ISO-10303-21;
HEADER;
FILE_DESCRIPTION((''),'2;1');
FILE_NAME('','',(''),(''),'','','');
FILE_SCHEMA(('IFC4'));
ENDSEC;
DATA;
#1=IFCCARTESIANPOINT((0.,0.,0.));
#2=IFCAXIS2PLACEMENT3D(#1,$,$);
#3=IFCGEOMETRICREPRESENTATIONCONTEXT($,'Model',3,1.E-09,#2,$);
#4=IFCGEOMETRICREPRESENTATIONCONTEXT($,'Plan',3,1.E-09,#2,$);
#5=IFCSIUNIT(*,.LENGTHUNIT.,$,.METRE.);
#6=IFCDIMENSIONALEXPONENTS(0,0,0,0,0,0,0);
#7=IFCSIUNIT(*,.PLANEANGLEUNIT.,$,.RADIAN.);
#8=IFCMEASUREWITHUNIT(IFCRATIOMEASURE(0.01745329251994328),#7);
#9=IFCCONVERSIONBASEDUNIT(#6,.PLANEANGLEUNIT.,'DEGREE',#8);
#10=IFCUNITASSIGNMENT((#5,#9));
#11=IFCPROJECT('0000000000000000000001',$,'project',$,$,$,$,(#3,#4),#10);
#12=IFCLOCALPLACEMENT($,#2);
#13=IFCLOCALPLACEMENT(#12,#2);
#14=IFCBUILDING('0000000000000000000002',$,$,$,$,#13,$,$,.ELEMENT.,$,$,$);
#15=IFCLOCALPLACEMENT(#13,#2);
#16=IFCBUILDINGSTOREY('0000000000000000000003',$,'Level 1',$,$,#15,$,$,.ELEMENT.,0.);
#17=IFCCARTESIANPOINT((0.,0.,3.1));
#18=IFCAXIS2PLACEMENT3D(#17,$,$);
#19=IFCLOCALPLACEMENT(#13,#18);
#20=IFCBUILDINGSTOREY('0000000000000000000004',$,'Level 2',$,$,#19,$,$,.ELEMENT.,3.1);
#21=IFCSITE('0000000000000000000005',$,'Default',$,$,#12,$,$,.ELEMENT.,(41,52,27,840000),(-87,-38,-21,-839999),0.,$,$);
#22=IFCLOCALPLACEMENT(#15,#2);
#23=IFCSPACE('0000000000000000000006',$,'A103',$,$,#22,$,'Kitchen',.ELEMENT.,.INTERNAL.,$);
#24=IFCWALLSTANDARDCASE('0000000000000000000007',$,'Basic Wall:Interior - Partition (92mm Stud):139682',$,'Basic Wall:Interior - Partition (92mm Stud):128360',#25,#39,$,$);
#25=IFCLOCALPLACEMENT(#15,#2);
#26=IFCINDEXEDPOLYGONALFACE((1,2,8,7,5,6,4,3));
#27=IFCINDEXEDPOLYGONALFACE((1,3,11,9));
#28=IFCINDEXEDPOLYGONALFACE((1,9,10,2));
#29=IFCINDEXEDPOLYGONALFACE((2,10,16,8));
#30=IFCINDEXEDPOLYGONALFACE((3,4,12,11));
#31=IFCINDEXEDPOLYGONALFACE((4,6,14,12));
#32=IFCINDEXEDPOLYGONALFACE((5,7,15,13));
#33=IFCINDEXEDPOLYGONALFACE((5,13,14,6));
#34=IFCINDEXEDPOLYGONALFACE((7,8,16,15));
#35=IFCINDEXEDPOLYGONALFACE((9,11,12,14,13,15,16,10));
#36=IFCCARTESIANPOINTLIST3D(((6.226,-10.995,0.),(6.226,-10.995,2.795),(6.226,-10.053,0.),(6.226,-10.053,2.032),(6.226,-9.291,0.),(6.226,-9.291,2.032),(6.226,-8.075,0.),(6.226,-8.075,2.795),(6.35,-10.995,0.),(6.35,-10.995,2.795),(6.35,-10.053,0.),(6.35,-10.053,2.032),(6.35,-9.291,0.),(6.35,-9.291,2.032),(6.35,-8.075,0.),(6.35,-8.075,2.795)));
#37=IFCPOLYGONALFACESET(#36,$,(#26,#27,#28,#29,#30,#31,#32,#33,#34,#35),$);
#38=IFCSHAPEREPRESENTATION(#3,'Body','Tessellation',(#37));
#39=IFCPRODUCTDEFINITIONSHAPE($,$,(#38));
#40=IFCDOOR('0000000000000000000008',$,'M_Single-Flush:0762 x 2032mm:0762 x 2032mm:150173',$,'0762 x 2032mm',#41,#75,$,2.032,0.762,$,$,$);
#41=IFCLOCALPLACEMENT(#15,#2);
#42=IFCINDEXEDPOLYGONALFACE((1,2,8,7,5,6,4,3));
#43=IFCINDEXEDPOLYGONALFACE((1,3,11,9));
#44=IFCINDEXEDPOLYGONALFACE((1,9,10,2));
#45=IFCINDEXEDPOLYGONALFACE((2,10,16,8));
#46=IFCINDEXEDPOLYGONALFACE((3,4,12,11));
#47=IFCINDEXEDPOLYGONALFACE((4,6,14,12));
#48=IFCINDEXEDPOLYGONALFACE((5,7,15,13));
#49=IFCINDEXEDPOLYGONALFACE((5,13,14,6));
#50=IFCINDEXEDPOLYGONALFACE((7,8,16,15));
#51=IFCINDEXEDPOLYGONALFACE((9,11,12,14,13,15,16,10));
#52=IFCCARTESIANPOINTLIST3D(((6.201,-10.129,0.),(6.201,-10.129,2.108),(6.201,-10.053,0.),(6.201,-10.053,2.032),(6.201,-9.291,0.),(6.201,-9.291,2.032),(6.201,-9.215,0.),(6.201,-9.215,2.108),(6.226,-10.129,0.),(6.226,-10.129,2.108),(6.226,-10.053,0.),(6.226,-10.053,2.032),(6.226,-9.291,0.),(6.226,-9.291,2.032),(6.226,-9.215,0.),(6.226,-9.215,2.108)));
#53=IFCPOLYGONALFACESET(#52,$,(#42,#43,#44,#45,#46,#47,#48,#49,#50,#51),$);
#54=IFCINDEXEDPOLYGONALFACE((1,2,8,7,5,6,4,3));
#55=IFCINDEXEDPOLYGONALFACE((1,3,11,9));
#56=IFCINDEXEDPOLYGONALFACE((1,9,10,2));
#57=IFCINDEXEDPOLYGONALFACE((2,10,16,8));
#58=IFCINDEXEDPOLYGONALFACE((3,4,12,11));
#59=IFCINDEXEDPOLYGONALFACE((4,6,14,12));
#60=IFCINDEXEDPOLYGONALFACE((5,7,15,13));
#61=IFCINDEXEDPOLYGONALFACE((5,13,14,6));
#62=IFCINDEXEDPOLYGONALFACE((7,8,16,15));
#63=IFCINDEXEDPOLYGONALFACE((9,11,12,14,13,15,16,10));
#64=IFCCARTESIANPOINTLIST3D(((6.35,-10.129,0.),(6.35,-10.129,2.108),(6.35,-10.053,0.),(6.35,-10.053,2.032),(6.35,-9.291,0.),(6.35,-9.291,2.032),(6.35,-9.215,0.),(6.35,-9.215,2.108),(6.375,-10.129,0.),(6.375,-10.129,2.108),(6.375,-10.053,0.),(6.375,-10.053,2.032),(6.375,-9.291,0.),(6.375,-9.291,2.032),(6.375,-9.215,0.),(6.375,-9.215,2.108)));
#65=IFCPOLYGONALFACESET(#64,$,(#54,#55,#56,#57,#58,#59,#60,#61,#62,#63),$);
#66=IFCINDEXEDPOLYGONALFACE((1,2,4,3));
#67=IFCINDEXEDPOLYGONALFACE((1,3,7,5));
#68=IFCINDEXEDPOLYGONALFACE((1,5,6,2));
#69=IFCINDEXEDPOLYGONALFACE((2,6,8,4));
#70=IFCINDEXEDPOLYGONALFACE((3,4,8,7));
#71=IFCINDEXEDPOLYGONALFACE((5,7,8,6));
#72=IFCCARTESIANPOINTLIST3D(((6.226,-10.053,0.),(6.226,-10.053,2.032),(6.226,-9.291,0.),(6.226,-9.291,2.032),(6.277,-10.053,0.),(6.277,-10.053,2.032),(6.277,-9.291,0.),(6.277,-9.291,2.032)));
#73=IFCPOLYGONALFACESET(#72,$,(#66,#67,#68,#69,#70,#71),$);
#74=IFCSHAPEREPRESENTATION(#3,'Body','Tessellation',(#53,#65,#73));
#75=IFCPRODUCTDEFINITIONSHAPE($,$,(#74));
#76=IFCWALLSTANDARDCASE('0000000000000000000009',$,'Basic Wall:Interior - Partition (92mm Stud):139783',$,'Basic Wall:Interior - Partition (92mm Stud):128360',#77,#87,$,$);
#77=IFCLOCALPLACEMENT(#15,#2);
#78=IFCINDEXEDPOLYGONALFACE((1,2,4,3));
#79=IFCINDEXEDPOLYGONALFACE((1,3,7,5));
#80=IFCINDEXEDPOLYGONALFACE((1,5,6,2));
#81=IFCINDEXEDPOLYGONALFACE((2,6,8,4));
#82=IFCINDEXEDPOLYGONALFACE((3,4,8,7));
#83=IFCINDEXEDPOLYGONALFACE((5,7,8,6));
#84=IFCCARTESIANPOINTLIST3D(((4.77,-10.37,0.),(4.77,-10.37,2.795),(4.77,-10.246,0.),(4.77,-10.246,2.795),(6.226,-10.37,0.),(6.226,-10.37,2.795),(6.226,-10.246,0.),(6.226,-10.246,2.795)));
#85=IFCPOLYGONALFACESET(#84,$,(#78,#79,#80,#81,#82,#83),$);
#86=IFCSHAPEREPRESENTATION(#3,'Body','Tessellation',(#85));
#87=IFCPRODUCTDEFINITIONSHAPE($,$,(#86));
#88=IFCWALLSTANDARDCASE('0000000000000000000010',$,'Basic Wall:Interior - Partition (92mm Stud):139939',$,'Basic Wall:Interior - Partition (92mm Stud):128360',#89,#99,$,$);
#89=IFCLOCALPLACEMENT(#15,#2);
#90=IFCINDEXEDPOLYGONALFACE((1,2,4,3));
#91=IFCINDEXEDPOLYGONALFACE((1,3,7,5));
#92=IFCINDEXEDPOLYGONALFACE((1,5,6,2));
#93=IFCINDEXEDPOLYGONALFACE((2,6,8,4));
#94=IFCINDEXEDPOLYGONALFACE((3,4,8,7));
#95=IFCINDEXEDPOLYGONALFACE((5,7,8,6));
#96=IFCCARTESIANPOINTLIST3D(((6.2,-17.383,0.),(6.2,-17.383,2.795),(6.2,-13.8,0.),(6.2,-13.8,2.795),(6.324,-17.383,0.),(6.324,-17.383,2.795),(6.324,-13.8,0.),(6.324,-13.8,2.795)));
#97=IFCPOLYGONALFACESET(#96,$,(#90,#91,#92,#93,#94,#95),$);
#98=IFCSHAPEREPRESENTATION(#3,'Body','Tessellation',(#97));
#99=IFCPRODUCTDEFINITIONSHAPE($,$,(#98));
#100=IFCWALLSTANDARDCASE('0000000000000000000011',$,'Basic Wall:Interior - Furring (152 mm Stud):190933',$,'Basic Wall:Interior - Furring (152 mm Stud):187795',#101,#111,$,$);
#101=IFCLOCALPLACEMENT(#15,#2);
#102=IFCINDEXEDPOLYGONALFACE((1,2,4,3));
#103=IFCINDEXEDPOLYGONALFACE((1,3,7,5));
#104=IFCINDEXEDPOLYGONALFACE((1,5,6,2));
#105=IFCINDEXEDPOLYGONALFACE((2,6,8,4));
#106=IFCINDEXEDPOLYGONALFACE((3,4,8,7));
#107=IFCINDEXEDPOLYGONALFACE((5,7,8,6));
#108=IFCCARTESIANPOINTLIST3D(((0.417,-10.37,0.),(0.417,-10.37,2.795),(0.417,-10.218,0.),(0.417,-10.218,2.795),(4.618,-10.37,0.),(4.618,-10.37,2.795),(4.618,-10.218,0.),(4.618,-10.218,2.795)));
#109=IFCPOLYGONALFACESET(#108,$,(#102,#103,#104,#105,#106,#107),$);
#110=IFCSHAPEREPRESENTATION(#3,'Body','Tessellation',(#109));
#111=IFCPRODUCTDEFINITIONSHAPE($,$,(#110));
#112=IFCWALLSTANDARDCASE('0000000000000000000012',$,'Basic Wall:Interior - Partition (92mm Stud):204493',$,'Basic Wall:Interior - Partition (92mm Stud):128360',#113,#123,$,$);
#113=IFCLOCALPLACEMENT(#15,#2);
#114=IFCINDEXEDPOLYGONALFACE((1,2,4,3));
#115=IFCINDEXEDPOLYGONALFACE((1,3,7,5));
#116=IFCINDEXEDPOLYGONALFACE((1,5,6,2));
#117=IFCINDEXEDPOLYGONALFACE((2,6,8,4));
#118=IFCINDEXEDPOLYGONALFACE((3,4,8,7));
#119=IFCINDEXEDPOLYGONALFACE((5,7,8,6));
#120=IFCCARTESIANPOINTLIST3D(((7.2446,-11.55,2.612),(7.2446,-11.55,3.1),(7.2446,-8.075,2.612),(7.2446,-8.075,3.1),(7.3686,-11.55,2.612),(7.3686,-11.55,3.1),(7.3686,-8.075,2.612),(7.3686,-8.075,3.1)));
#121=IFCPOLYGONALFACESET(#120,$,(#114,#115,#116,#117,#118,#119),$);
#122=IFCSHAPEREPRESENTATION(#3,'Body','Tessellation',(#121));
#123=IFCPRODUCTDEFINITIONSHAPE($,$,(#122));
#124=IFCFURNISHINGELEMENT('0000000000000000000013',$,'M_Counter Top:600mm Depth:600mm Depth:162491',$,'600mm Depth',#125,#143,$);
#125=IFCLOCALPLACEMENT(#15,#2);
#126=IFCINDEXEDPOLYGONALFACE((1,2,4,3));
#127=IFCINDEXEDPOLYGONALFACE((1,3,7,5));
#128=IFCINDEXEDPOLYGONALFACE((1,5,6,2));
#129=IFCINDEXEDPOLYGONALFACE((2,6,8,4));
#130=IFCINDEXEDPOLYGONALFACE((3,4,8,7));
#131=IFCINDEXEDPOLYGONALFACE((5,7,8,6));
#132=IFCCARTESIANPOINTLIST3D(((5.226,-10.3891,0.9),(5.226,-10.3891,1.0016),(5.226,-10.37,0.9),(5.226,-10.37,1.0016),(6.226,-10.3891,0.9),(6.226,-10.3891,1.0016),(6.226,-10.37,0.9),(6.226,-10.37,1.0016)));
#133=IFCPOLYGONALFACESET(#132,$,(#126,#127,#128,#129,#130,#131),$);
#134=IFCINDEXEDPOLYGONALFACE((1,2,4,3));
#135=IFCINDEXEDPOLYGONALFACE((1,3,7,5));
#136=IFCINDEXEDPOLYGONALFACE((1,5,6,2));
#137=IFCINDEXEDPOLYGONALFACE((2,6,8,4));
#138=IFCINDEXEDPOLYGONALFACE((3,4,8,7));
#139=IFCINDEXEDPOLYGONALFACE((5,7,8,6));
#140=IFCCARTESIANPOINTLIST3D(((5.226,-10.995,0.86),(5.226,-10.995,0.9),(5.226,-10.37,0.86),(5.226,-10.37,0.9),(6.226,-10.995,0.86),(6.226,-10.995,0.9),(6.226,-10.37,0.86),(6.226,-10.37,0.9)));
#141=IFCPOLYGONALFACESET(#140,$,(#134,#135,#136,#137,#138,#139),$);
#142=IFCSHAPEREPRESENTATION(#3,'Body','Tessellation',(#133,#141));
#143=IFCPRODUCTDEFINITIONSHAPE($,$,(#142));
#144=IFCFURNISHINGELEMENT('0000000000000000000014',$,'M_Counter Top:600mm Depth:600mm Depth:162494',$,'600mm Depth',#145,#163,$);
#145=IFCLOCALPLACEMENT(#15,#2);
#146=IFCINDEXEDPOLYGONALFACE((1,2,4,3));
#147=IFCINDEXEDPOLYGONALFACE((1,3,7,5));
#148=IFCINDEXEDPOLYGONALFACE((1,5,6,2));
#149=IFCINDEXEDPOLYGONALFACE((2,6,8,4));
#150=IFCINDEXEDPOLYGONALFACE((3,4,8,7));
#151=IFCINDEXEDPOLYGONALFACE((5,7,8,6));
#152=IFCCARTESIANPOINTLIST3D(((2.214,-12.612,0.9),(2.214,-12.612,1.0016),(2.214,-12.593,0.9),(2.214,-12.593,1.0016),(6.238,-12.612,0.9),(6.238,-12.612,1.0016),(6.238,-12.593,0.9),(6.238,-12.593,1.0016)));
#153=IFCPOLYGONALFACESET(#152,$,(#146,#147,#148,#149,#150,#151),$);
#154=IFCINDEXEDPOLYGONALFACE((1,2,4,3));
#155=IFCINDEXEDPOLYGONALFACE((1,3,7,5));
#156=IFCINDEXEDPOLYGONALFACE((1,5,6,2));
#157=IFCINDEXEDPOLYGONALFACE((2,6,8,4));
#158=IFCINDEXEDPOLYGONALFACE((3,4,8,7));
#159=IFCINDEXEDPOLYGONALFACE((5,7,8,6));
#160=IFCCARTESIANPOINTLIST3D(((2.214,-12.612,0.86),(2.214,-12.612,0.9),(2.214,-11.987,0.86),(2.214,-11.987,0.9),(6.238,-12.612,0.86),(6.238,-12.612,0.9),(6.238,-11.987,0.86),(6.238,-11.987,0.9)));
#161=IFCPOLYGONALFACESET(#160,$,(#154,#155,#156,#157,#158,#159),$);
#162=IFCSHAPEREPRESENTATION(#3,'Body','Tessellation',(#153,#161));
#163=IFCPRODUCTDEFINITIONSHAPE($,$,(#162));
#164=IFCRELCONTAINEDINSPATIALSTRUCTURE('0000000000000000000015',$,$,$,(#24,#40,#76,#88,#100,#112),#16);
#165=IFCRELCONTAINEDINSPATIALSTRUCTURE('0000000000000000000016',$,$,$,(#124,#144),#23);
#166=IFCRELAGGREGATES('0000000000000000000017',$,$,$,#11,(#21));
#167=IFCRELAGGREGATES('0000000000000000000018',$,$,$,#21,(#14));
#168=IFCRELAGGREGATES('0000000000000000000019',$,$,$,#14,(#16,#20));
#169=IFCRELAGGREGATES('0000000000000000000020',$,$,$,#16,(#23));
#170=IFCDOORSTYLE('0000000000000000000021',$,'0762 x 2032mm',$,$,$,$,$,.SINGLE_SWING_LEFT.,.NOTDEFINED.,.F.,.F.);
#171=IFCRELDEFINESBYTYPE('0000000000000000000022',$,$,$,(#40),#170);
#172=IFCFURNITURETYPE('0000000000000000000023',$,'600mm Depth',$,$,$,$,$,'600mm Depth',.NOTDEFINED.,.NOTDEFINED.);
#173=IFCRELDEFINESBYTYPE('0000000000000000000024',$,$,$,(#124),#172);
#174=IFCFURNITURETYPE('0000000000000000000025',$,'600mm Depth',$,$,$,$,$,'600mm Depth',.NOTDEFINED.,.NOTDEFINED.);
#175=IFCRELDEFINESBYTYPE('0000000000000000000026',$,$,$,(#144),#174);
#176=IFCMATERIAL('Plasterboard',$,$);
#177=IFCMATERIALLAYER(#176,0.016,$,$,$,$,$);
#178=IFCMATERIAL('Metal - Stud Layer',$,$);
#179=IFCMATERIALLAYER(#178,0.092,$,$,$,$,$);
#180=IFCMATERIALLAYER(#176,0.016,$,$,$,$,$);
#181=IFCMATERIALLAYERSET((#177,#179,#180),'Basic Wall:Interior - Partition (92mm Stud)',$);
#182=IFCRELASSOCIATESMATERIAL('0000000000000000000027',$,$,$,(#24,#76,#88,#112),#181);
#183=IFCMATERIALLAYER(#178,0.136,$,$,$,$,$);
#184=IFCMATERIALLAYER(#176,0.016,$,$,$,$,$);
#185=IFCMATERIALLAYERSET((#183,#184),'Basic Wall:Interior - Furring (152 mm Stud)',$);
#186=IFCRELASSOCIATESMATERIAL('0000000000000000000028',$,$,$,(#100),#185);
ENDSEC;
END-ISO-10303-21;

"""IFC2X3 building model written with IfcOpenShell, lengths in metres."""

from ifc_helpers import new_model, entity, si_unit, converted_unit, frame, frame_2d, origin, origin_2d_with_axis, place, context, project, spatial, polyline, rectangle, outline, extrude, source, transform, mapped, material, layer, layer_set, layer_usage, type_object, type_shapes, element, fill, save


model = new_model("IFC2X3")

# Units and contexts
model_context = context("Model", 3, precision=1e-09, world=origin())
plan_context = context("Plan", 3, precision=1e-09, world=origin())
ifc_project = project(units=[si_unit("LENGTHUNIT", "METRE"), converted_unit("PLANEANGLEUNIT", "DEGREE", entity("IfcRatioMeasure", 0.01745329251994328), si_unit("PLANEANGLEUNIT", "RADIAN"), dimensions=[0, 0, 0, 0, 0, 0, 0])], contexts=[model_context, plan_context])

# Site, building, storey
site_placement = place(None, origin())
site = spatial("IfcSite", under=ifc_project, at=site_placement, Name="Default", CompositionType="ELEMENT", RefLatitude=(41, 52, 27, 840000), RefLongitude=(-87, -38, -21, -839999), RefElevation=0.0)
building_placement = place(site_placement, origin())
building = spatial("IfcBuilding", under=site, at=building_placement, CompositionType="ELEMENT")
storey_1_placement = place(building_placement, origin())
storey_1 = spatial("IfcBuildingStorey", under=building, at=storey_1_placement, Name="Level 1", CompositionType="ELEMENT", Elevation=0.0)

# Shared definitions
ifc_material_1 = material(Name="Metal - Stud Layer")
ifc_material_2 = material(Name="Plasterboard")

# Wall, opening, door
ifc_layer_1 = layer(ifc_material_2, 0.016)
ifc_layer_2 = layer(ifc_material_1, 0.092)
ifc_layer_3 = layer(ifc_material_2, 0.016)
ifc_layer_set_1 = layer_set([ifc_layer_1, ifc_layer_2, ifc_layer_3], Name="Basic Wall:Interior - Partition (92mm Stud)")
ifc_layer_usage_1 = layer_usage(ifc_layer_set_1, "AXIS2", "NEGATIVE", 0.062)
wall_1_placement = place(storey_1_placement, frame((6.288, -10.995, 0.0), z_axis=(0.0, 0.0, 1.0), x_axis=(0.0, 1.0, 0.0)))
wall_1 = element("IfcWallStandardCase", 1, at=wall_1_placement, inside=storey_1, material=ifc_layer_usage_1, Name="Basic Wall:Interior - Partition (92mm Stud):139682", ObjectType="Basic Wall:Interior - Partition (92mm Stud):128360", context=model_context, shape_type="SweptSolid", body=[
    extrude(rectangle(XDim=2.92, YDim=0.124, at=frame_2d((1.46, 0.0), x_axis=(-1.0, 0.0))), origin(), (0.0, 0.0, 1.0), 2.795),
])
opening_1_placement = place(wall_1_placement, frame((0.942, -0.062, 0.0)))
opening_1 = element("IfcOpeningElement", 2, at=opening_1_placement, cuts=wall_1, ObjectType="Opening", context=model_context, shape_type="SweptSolid", body=[
    extrude(rectangle(XDim=0.762, YDim=2.032, at=frame_2d((1.016, 0.381), x_axis=(0.0, -1.0))), frame((0.0, 0.0, 0.0), z_axis=(0.0, 1.0, 0.0), x_axis=(0.0, 0.0, 1.0)), (0.0, 0.0, 1.0), 0.124),
])
door_style_1 = type_object("IfcDoorStyle", Name="0762 x 2032mm", ConstructionType="NOTDEFINED", OperationType="SINGLE_SWING_LEFT", ParameterTakesPrecedence=False, Sizeable=False)
shared_shape_1 = source(origin(), model_context, "Body", "SweptSolid", [
    extrude(outline(polyline([(-0.457, -1.073), (0.457, -1.073), (0.457, 1.035), (0.381, 1.035), (0.381, -0.997), (-0.381, -0.997), (-0.381, 1.035), (-0.457, 1.035), (-0.457, -1.073)])), frame((0.381, 0.149, 1.035), z_axis=(0.0, -1.0, 0.0), x_axis=(-1.0, 0.0, 0.0)), (0.0, 0.0, 1.0), 0.025),
    extrude(outline(polyline([(-1.073, -0.457), (1.035, -0.457), (1.035, -0.381), (-0.997, -0.381), (-0.997, 0.381), (1.035, 0.381), (1.035, 0.457), (-1.073, 0.457), (-1.073, -0.457)])), frame((0.381, 0.0, 1.035), z_axis=(0.0, -1.0, 0.0), x_axis=(0.0, 0.0, -1.0)), (0.0, 0.0, 1.0), 0.025),
    extrude(rectangle(XDim=0.762, YDim=0.051, at=origin_2d_with_axis()), frame((0.381, 0.0985, 0.0)), (0.0, 0.0, 1.0), 2.032),
])
type_shapes(door_style_1, [shared_shape_1])
door_1_placement = place(opening_1_placement, origin())
door_1 = element("IfcDoor", 3, at=door_1_placement, inside=storey_1, type_object=door_style_1, Name="M_Single-Flush:0762 x 2032mm:0762 x 2032mm:150173", ObjectType="0762 x 2032mm", OverallHeight=2.032, OverallWidth=0.762, context=model_context, shape_type="MappedRepresentation", body=[
    mapped(shared_shape_1, transform((0.0, 0.0, 0.0), scale=1.0)),
])
fill(opening_1, door_1)

# Walls
ifc_layer_usage_2 = layer_usage(ifc_layer_set_1, "AXIS2", "NEGATIVE", 0.062)
wall_2_placement = place(storey_1_placement, frame((4.77, -10.308, 0.0)))
element("IfcWallStandardCase", 4, at=wall_2_placement, inside=storey_1, material=ifc_layer_usage_2, Name="Basic Wall:Interior - Partition (92mm Stud):139783", ObjectType="Basic Wall:Interior - Partition (92mm Stud):128360", context=model_context, shape_type="SweptSolid", body=[
    extrude(rectangle(XDim=1.456, YDim=0.124, at=frame_2d((0.728, 0.0), x_axis=(-1.0, 0.0))), origin(), (0.0, 0.0, 1.0), 2.795),
])
ifc_layer_usage_3 = layer_usage(ifc_layer_set_1, "AXIS2", "NEGATIVE", 0.062)
wall_3_placement = place(storey_1_placement, frame((6.262, -13.8, 0.0), z_axis=(0.0, 0.0, 1.0), x_axis=(0.0, -1.0, 0.0)))
element("IfcWallStandardCase", 5, at=wall_3_placement, inside=storey_1, material=ifc_layer_usage_3, Name="Basic Wall:Interior - Partition (92mm Stud):139939", ObjectType="Basic Wall:Interior - Partition (92mm Stud):128360", context=model_context, shape_type="SweptSolid", body=[
    extrude(rectangle(XDim=3.583, YDim=0.124, at=frame_2d((1.7915, 0.0), x_axis=(-1.0, 0.0))), origin(), (0.0, 0.0, 1.0), 2.795),
])

# Shared definitions
storey_2_placement = place(building_placement, frame((0.0, 0.0, 3.1)))
storey_2 = spatial("IfcBuildingStorey", under=building, at=storey_2_placement, Name="Level 2", CompositionType="ELEMENT", Elevation=3.1)

# Walls
ifc_layer_4 = layer(ifc_material_1, 0.136)
ifc_layer_5 = layer(ifc_material_2, 0.016)
ifc_layer_set_2 = layer_set([ifc_layer_4, ifc_layer_5], Name="Basic Wall:Interior - Furring (152 mm Stud)")
ifc_layer_usage_4 = layer_usage(ifc_layer_set_2, "AXIS2", "NEGATIVE", 0.076)
wall_4_placement = place(storey_1_placement, frame((0.417, -10.294, 0.0)))
element("IfcWallStandardCase", 6, at=wall_4_placement, inside=storey_1, material=ifc_layer_usage_4, Name="Basic Wall:Interior - Furring (152 mm Stud):190933", ObjectType="Basic Wall:Interior - Furring (152 mm Stud):187795", context=model_context, shape_type="SweptSolid", body=[
    extrude(rectangle(XDim=4.201, YDim=0.152, at=frame_2d((2.1005, 0.0), x_axis=(-1.0, 0.0))), origin(), (0.0, 0.0, 1.0), 2.795),
])
ifc_layer_usage_5 = layer_usage(ifc_layer_set_1, "AXIS2", "NEGATIVE", 0.062)
wall_5_placement = place(storey_1_placement, frame((7.3066, -11.55, 2.612), z_axis=(0.0, 0.0, 1.0), x_axis=(0.0, 1.0, 0.0)))
element("IfcWallStandardCase", 7, at=wall_5_placement, inside=storey_1, material=ifc_layer_usage_5, Name="Basic Wall:Interior - Partition (92mm Stud):204493", ObjectType="Basic Wall:Interior - Partition (92mm Stud):128360", context=model_context, shape_type="SweptSolid", body=[
    extrude(rectangle(XDim=3.475, YDim=0.124, at=frame_2d((1.7375, 0.0), x_axis=(-1.0, 0.0))), origin(), (0.0, 0.0, 1.0), 0.488),
])

# Shared definitions
space_1_placement = place(storey_1_placement, origin())
space_1 = spatial("IfcSpace", under=storey_1, at=space_1_placement, Name="A103", LongName="Kitchen", CompositionType="ELEMENT", InteriorOrExteriorSpace="INTERNAL")

# Furnishing elements
furniture_type_1 = type_object("IfcFurnitureType", Name="600mm Depth", ElementType="600mm Depth", AssemblyPlace="NOTDEFINED")
shared_shape_2 = source(origin(), model_context, "Body", "SweptSolid", [
    extrude(rectangle(XDim=0.0191, YDim=1.0, at=origin_2d_with_axis()), frame((-0.7005, -0.0095, 0.9), z_axis=(0.0, 0.0, 1.0), x_axis=(0.0, -1.0, 0.0)), (0.0, 0.0, 1.0), 0.1016),
    extrude(rectangle(XDim=1.0, YDim=0.625, at=origin_2d_with_axis()), frame((-0.7005, -0.3125, 0.86), z_axis=(0.0, 0.0, 1.0), x_axis=(-1.0, 0.0, 0.0)), (0.0, 0.0, 1.0), 0.04),
])
type_shapes(furniture_type_1, [shared_shape_2])
furnishing_1_placement = place(space_1_placement, frame((6.4265, -10.37, 0.0)))
element("IfcFurnishingElement", 8, at=furnishing_1_placement, inside=space_1, type_object=furniture_type_1, Name="M_Counter Top:600mm Depth:600mm Depth:162491", ObjectType="600mm Depth", context=model_context, shape_type="MappedRepresentation", body=[
    mapped(shared_shape_2, transform((0.0, 0.0, 0.0), scale=1.0)),
])
furniture_type_2 = type_object("IfcFurnitureType", Name="600mm Depth", ElementType="600mm Depth", AssemblyPlace="NOTDEFINED")
shared_shape_3 = source(origin(), model_context, "Body", "SweptSolid", [
    extrude(rectangle(XDim=0.0191, YDim=4.024, at=origin_2d_with_axis()), frame((0.8115, -0.0095, 0.9), z_axis=(0.0, 0.0, 1.0), x_axis=(0.0, -1.0, 0.0)), (0.0, 0.0, 1.0), 0.1016),
    extrude(rectangle(XDim=4.024, YDim=0.625, at=origin_2d_with_axis()), frame((0.8115, -0.3125, 0.86), z_axis=(0.0, 0.0, 1.0), x_axis=(-1.0, 0.0, 0.0)), (0.0, 0.0, 1.0), 0.04),
])
type_shapes(furniture_type_2, [shared_shape_3])
furnishing_2_placement = place(space_1_placement, frame((5.0375, -12.612, 0.0), z_axis=(0.0, 0.0, 1.0), x_axis=(-1.0, 0.0, 0.0)))
element("IfcFurnishingElement", 9, at=furnishing_2_placement, inside=space_1, type_object=furniture_type_2, Name="M_Counter Top:600mm Depth:600mm Depth:162494", ObjectType="600mm Depth", context=model_context, shape_type="MappedRepresentation", body=[
    mapped(shared_shape_3, transform((0.0, 0.0, 0.0), scale=1.0)),
])

save(model, "model.ifc")
